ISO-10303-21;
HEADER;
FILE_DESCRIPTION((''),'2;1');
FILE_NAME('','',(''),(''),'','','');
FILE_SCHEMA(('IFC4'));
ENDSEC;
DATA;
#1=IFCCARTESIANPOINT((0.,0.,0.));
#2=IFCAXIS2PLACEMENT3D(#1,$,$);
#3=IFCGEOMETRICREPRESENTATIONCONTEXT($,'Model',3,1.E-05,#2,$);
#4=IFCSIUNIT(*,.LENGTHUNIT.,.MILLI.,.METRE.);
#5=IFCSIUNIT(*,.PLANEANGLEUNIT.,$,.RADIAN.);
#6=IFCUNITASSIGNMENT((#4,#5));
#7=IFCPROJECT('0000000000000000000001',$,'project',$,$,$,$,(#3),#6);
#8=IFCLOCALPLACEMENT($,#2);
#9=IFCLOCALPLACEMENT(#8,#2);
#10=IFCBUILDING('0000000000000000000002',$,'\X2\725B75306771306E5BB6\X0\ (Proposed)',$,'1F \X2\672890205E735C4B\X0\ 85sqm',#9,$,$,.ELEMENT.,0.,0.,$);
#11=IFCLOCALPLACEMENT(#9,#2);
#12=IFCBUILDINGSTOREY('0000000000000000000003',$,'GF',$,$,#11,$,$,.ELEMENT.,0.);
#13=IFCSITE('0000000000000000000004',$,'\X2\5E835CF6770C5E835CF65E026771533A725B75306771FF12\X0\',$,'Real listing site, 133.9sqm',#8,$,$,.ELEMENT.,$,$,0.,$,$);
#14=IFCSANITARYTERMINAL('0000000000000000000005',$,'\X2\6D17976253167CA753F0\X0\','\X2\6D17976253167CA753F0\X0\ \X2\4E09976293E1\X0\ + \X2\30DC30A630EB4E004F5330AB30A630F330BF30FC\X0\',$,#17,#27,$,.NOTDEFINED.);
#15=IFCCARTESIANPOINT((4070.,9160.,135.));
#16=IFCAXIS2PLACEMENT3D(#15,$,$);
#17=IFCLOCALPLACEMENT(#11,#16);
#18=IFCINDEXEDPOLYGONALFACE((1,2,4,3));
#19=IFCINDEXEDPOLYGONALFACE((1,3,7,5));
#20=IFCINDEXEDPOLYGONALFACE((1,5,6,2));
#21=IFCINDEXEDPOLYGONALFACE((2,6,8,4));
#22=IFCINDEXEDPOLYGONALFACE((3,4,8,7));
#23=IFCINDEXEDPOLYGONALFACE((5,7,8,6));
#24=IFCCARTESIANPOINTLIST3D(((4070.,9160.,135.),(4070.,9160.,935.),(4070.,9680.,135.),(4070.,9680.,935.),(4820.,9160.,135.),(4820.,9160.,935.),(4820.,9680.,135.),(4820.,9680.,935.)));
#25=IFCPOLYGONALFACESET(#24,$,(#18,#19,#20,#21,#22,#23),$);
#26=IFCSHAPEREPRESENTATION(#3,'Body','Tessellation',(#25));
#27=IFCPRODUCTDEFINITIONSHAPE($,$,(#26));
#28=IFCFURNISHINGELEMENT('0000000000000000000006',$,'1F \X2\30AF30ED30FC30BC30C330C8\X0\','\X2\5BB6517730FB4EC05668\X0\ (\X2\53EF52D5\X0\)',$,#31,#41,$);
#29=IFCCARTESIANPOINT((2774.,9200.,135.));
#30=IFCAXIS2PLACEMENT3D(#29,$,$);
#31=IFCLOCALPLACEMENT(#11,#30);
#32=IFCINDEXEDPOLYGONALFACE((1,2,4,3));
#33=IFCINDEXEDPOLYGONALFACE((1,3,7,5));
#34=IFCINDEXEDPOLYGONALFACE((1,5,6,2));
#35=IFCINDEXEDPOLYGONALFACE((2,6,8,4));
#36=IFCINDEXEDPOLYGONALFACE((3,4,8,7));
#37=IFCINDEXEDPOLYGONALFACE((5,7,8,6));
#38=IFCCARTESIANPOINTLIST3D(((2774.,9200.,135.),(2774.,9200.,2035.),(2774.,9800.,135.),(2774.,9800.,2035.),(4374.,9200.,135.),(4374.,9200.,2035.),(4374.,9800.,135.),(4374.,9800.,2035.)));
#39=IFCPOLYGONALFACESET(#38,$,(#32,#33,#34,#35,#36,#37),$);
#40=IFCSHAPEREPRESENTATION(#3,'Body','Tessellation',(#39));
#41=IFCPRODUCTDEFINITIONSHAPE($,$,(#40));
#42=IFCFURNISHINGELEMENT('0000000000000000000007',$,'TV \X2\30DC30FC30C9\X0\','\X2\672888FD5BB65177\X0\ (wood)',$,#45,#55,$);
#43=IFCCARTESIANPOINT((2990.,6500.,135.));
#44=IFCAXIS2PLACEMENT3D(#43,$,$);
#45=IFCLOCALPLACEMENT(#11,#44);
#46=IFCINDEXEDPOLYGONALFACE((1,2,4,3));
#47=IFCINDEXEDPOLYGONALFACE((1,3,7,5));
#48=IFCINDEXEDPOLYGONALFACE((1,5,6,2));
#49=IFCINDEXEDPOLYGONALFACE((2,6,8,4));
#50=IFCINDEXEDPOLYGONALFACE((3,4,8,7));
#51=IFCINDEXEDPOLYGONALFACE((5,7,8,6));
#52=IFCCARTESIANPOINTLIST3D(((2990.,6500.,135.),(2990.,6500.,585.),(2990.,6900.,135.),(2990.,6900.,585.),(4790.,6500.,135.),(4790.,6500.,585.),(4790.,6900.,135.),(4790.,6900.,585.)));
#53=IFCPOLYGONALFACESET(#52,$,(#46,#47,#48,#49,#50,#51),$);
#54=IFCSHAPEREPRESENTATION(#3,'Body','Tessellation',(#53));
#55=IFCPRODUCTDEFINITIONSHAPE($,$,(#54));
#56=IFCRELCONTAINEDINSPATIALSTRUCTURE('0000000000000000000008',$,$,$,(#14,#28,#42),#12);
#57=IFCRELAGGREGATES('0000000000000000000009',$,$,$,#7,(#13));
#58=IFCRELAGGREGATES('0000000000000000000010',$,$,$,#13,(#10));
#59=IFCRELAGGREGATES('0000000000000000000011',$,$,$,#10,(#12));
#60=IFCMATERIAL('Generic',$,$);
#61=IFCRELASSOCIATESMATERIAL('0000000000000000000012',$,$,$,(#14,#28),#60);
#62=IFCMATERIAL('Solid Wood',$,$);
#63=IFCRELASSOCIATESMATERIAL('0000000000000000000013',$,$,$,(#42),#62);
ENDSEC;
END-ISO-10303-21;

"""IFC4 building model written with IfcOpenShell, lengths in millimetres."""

from ifc_helpers import new_model, si_unit, frame, frame_2d, origin, place, context, project, spatial, rectangle, extrude, material, element, save


model = new_model("IFC4")

# Units and contexts
model_context = context("Model", 3, precision=1e-05, world=origin())
ifc_project = project(units=[si_unit("LENGTHUNIT", "METRE", prefix="MILLI"), si_unit("PLANEANGLEUNIT", "RADIAN")], contexts=[model_context])

# Site, building, storey
site_placement = place(None, origin())
site = spatial("IfcSite", under=ifc_project, at=site_placement, Name="広島県広島市東区牛田東２", ObjectType="Real listing site, 133.9sqm", CompositionType="ELEMENT", RefElevation=0.0)
building_placement = place(site_placement, origin())
building = spatial("IfcBuilding", under=site, at=building_placement, Name="牛田東の家 (Proposed)", ObjectType="1F 木造平屋 85sqm", CompositionType="ELEMENT", ElevationOfRefHeight=0.0, ElevationOfTerrain=0.0)
storey_placement = place(building_placement, origin())
storey = spatial("IfcBuildingStorey", under=building, at=storey_placement, Name="GF", CompositionType="ELEMENT", Elevation=0.0)

# Shared definitions
ifc_material_1 = material(Name="Solid Wood")

# Shared definitions
ifc_material_2 = material(Name="Generic")

# Sanitary terminal
sanitary_terminal_1_placement = place(storey_placement, frame((4070.0, 9160.0, 135.0)))
element("IfcSanitaryTerminal", 1, at=sanitary_terminal_1_placement, inside=storey, material=ifc_material_2, Name="洗面化粧台", Description="洗面化粧台 三面鏡 + ボウル一体カウンター", PredefinedType="NOTDEFINED", context=model_context, shape_type="SweptSolid", body=[
    extrude(rectangle(XDim=750.0, YDim=520.0, at=frame_2d((375.0, 260.0))), frame((4070.0, 9160.0, 135.0)), (0.0, 0.0, 1.0), 800.0),
])

# Furnishing elements
furnishing_1_placement = place(storey_placement, frame((2774.0, 9200.0, 135.0)))
element("IfcFurnishingElement", 2, at=furnishing_1_placement, inside=storey, material=ifc_material_2, Name="1F クローゼット", Description="家具・什器 (可動)", context=model_context, shape_type="SweptSolid", body=[
    extrude(rectangle(XDim=1600.0, YDim=600.0, at=frame_2d((800.0, 300.0))), frame((2774.0, 9200.0, 135.0)), (0.0, 0.0, 1.0), 1900.0),
])
furnishing_2_placement = place(storey_placement, frame((2990.0, 6500.0, 135.0)))
element("IfcFurnishingElement", 3, at=furnishing_2_placement, inside=storey, material=ifc_material_1, Name="TV ボード", Description="木製家具 (wood)", context=model_context, shape_type="SweptSolid", body=[
    extrude(rectangle(XDim=1800.0, YDim=400.0, at=frame_2d((900.0, 200.0))), frame((2990.0, 6500.0, 135.0)), (0.0, 0.0, 1.0), 450.0),
])

save(model, "model.ifc")
